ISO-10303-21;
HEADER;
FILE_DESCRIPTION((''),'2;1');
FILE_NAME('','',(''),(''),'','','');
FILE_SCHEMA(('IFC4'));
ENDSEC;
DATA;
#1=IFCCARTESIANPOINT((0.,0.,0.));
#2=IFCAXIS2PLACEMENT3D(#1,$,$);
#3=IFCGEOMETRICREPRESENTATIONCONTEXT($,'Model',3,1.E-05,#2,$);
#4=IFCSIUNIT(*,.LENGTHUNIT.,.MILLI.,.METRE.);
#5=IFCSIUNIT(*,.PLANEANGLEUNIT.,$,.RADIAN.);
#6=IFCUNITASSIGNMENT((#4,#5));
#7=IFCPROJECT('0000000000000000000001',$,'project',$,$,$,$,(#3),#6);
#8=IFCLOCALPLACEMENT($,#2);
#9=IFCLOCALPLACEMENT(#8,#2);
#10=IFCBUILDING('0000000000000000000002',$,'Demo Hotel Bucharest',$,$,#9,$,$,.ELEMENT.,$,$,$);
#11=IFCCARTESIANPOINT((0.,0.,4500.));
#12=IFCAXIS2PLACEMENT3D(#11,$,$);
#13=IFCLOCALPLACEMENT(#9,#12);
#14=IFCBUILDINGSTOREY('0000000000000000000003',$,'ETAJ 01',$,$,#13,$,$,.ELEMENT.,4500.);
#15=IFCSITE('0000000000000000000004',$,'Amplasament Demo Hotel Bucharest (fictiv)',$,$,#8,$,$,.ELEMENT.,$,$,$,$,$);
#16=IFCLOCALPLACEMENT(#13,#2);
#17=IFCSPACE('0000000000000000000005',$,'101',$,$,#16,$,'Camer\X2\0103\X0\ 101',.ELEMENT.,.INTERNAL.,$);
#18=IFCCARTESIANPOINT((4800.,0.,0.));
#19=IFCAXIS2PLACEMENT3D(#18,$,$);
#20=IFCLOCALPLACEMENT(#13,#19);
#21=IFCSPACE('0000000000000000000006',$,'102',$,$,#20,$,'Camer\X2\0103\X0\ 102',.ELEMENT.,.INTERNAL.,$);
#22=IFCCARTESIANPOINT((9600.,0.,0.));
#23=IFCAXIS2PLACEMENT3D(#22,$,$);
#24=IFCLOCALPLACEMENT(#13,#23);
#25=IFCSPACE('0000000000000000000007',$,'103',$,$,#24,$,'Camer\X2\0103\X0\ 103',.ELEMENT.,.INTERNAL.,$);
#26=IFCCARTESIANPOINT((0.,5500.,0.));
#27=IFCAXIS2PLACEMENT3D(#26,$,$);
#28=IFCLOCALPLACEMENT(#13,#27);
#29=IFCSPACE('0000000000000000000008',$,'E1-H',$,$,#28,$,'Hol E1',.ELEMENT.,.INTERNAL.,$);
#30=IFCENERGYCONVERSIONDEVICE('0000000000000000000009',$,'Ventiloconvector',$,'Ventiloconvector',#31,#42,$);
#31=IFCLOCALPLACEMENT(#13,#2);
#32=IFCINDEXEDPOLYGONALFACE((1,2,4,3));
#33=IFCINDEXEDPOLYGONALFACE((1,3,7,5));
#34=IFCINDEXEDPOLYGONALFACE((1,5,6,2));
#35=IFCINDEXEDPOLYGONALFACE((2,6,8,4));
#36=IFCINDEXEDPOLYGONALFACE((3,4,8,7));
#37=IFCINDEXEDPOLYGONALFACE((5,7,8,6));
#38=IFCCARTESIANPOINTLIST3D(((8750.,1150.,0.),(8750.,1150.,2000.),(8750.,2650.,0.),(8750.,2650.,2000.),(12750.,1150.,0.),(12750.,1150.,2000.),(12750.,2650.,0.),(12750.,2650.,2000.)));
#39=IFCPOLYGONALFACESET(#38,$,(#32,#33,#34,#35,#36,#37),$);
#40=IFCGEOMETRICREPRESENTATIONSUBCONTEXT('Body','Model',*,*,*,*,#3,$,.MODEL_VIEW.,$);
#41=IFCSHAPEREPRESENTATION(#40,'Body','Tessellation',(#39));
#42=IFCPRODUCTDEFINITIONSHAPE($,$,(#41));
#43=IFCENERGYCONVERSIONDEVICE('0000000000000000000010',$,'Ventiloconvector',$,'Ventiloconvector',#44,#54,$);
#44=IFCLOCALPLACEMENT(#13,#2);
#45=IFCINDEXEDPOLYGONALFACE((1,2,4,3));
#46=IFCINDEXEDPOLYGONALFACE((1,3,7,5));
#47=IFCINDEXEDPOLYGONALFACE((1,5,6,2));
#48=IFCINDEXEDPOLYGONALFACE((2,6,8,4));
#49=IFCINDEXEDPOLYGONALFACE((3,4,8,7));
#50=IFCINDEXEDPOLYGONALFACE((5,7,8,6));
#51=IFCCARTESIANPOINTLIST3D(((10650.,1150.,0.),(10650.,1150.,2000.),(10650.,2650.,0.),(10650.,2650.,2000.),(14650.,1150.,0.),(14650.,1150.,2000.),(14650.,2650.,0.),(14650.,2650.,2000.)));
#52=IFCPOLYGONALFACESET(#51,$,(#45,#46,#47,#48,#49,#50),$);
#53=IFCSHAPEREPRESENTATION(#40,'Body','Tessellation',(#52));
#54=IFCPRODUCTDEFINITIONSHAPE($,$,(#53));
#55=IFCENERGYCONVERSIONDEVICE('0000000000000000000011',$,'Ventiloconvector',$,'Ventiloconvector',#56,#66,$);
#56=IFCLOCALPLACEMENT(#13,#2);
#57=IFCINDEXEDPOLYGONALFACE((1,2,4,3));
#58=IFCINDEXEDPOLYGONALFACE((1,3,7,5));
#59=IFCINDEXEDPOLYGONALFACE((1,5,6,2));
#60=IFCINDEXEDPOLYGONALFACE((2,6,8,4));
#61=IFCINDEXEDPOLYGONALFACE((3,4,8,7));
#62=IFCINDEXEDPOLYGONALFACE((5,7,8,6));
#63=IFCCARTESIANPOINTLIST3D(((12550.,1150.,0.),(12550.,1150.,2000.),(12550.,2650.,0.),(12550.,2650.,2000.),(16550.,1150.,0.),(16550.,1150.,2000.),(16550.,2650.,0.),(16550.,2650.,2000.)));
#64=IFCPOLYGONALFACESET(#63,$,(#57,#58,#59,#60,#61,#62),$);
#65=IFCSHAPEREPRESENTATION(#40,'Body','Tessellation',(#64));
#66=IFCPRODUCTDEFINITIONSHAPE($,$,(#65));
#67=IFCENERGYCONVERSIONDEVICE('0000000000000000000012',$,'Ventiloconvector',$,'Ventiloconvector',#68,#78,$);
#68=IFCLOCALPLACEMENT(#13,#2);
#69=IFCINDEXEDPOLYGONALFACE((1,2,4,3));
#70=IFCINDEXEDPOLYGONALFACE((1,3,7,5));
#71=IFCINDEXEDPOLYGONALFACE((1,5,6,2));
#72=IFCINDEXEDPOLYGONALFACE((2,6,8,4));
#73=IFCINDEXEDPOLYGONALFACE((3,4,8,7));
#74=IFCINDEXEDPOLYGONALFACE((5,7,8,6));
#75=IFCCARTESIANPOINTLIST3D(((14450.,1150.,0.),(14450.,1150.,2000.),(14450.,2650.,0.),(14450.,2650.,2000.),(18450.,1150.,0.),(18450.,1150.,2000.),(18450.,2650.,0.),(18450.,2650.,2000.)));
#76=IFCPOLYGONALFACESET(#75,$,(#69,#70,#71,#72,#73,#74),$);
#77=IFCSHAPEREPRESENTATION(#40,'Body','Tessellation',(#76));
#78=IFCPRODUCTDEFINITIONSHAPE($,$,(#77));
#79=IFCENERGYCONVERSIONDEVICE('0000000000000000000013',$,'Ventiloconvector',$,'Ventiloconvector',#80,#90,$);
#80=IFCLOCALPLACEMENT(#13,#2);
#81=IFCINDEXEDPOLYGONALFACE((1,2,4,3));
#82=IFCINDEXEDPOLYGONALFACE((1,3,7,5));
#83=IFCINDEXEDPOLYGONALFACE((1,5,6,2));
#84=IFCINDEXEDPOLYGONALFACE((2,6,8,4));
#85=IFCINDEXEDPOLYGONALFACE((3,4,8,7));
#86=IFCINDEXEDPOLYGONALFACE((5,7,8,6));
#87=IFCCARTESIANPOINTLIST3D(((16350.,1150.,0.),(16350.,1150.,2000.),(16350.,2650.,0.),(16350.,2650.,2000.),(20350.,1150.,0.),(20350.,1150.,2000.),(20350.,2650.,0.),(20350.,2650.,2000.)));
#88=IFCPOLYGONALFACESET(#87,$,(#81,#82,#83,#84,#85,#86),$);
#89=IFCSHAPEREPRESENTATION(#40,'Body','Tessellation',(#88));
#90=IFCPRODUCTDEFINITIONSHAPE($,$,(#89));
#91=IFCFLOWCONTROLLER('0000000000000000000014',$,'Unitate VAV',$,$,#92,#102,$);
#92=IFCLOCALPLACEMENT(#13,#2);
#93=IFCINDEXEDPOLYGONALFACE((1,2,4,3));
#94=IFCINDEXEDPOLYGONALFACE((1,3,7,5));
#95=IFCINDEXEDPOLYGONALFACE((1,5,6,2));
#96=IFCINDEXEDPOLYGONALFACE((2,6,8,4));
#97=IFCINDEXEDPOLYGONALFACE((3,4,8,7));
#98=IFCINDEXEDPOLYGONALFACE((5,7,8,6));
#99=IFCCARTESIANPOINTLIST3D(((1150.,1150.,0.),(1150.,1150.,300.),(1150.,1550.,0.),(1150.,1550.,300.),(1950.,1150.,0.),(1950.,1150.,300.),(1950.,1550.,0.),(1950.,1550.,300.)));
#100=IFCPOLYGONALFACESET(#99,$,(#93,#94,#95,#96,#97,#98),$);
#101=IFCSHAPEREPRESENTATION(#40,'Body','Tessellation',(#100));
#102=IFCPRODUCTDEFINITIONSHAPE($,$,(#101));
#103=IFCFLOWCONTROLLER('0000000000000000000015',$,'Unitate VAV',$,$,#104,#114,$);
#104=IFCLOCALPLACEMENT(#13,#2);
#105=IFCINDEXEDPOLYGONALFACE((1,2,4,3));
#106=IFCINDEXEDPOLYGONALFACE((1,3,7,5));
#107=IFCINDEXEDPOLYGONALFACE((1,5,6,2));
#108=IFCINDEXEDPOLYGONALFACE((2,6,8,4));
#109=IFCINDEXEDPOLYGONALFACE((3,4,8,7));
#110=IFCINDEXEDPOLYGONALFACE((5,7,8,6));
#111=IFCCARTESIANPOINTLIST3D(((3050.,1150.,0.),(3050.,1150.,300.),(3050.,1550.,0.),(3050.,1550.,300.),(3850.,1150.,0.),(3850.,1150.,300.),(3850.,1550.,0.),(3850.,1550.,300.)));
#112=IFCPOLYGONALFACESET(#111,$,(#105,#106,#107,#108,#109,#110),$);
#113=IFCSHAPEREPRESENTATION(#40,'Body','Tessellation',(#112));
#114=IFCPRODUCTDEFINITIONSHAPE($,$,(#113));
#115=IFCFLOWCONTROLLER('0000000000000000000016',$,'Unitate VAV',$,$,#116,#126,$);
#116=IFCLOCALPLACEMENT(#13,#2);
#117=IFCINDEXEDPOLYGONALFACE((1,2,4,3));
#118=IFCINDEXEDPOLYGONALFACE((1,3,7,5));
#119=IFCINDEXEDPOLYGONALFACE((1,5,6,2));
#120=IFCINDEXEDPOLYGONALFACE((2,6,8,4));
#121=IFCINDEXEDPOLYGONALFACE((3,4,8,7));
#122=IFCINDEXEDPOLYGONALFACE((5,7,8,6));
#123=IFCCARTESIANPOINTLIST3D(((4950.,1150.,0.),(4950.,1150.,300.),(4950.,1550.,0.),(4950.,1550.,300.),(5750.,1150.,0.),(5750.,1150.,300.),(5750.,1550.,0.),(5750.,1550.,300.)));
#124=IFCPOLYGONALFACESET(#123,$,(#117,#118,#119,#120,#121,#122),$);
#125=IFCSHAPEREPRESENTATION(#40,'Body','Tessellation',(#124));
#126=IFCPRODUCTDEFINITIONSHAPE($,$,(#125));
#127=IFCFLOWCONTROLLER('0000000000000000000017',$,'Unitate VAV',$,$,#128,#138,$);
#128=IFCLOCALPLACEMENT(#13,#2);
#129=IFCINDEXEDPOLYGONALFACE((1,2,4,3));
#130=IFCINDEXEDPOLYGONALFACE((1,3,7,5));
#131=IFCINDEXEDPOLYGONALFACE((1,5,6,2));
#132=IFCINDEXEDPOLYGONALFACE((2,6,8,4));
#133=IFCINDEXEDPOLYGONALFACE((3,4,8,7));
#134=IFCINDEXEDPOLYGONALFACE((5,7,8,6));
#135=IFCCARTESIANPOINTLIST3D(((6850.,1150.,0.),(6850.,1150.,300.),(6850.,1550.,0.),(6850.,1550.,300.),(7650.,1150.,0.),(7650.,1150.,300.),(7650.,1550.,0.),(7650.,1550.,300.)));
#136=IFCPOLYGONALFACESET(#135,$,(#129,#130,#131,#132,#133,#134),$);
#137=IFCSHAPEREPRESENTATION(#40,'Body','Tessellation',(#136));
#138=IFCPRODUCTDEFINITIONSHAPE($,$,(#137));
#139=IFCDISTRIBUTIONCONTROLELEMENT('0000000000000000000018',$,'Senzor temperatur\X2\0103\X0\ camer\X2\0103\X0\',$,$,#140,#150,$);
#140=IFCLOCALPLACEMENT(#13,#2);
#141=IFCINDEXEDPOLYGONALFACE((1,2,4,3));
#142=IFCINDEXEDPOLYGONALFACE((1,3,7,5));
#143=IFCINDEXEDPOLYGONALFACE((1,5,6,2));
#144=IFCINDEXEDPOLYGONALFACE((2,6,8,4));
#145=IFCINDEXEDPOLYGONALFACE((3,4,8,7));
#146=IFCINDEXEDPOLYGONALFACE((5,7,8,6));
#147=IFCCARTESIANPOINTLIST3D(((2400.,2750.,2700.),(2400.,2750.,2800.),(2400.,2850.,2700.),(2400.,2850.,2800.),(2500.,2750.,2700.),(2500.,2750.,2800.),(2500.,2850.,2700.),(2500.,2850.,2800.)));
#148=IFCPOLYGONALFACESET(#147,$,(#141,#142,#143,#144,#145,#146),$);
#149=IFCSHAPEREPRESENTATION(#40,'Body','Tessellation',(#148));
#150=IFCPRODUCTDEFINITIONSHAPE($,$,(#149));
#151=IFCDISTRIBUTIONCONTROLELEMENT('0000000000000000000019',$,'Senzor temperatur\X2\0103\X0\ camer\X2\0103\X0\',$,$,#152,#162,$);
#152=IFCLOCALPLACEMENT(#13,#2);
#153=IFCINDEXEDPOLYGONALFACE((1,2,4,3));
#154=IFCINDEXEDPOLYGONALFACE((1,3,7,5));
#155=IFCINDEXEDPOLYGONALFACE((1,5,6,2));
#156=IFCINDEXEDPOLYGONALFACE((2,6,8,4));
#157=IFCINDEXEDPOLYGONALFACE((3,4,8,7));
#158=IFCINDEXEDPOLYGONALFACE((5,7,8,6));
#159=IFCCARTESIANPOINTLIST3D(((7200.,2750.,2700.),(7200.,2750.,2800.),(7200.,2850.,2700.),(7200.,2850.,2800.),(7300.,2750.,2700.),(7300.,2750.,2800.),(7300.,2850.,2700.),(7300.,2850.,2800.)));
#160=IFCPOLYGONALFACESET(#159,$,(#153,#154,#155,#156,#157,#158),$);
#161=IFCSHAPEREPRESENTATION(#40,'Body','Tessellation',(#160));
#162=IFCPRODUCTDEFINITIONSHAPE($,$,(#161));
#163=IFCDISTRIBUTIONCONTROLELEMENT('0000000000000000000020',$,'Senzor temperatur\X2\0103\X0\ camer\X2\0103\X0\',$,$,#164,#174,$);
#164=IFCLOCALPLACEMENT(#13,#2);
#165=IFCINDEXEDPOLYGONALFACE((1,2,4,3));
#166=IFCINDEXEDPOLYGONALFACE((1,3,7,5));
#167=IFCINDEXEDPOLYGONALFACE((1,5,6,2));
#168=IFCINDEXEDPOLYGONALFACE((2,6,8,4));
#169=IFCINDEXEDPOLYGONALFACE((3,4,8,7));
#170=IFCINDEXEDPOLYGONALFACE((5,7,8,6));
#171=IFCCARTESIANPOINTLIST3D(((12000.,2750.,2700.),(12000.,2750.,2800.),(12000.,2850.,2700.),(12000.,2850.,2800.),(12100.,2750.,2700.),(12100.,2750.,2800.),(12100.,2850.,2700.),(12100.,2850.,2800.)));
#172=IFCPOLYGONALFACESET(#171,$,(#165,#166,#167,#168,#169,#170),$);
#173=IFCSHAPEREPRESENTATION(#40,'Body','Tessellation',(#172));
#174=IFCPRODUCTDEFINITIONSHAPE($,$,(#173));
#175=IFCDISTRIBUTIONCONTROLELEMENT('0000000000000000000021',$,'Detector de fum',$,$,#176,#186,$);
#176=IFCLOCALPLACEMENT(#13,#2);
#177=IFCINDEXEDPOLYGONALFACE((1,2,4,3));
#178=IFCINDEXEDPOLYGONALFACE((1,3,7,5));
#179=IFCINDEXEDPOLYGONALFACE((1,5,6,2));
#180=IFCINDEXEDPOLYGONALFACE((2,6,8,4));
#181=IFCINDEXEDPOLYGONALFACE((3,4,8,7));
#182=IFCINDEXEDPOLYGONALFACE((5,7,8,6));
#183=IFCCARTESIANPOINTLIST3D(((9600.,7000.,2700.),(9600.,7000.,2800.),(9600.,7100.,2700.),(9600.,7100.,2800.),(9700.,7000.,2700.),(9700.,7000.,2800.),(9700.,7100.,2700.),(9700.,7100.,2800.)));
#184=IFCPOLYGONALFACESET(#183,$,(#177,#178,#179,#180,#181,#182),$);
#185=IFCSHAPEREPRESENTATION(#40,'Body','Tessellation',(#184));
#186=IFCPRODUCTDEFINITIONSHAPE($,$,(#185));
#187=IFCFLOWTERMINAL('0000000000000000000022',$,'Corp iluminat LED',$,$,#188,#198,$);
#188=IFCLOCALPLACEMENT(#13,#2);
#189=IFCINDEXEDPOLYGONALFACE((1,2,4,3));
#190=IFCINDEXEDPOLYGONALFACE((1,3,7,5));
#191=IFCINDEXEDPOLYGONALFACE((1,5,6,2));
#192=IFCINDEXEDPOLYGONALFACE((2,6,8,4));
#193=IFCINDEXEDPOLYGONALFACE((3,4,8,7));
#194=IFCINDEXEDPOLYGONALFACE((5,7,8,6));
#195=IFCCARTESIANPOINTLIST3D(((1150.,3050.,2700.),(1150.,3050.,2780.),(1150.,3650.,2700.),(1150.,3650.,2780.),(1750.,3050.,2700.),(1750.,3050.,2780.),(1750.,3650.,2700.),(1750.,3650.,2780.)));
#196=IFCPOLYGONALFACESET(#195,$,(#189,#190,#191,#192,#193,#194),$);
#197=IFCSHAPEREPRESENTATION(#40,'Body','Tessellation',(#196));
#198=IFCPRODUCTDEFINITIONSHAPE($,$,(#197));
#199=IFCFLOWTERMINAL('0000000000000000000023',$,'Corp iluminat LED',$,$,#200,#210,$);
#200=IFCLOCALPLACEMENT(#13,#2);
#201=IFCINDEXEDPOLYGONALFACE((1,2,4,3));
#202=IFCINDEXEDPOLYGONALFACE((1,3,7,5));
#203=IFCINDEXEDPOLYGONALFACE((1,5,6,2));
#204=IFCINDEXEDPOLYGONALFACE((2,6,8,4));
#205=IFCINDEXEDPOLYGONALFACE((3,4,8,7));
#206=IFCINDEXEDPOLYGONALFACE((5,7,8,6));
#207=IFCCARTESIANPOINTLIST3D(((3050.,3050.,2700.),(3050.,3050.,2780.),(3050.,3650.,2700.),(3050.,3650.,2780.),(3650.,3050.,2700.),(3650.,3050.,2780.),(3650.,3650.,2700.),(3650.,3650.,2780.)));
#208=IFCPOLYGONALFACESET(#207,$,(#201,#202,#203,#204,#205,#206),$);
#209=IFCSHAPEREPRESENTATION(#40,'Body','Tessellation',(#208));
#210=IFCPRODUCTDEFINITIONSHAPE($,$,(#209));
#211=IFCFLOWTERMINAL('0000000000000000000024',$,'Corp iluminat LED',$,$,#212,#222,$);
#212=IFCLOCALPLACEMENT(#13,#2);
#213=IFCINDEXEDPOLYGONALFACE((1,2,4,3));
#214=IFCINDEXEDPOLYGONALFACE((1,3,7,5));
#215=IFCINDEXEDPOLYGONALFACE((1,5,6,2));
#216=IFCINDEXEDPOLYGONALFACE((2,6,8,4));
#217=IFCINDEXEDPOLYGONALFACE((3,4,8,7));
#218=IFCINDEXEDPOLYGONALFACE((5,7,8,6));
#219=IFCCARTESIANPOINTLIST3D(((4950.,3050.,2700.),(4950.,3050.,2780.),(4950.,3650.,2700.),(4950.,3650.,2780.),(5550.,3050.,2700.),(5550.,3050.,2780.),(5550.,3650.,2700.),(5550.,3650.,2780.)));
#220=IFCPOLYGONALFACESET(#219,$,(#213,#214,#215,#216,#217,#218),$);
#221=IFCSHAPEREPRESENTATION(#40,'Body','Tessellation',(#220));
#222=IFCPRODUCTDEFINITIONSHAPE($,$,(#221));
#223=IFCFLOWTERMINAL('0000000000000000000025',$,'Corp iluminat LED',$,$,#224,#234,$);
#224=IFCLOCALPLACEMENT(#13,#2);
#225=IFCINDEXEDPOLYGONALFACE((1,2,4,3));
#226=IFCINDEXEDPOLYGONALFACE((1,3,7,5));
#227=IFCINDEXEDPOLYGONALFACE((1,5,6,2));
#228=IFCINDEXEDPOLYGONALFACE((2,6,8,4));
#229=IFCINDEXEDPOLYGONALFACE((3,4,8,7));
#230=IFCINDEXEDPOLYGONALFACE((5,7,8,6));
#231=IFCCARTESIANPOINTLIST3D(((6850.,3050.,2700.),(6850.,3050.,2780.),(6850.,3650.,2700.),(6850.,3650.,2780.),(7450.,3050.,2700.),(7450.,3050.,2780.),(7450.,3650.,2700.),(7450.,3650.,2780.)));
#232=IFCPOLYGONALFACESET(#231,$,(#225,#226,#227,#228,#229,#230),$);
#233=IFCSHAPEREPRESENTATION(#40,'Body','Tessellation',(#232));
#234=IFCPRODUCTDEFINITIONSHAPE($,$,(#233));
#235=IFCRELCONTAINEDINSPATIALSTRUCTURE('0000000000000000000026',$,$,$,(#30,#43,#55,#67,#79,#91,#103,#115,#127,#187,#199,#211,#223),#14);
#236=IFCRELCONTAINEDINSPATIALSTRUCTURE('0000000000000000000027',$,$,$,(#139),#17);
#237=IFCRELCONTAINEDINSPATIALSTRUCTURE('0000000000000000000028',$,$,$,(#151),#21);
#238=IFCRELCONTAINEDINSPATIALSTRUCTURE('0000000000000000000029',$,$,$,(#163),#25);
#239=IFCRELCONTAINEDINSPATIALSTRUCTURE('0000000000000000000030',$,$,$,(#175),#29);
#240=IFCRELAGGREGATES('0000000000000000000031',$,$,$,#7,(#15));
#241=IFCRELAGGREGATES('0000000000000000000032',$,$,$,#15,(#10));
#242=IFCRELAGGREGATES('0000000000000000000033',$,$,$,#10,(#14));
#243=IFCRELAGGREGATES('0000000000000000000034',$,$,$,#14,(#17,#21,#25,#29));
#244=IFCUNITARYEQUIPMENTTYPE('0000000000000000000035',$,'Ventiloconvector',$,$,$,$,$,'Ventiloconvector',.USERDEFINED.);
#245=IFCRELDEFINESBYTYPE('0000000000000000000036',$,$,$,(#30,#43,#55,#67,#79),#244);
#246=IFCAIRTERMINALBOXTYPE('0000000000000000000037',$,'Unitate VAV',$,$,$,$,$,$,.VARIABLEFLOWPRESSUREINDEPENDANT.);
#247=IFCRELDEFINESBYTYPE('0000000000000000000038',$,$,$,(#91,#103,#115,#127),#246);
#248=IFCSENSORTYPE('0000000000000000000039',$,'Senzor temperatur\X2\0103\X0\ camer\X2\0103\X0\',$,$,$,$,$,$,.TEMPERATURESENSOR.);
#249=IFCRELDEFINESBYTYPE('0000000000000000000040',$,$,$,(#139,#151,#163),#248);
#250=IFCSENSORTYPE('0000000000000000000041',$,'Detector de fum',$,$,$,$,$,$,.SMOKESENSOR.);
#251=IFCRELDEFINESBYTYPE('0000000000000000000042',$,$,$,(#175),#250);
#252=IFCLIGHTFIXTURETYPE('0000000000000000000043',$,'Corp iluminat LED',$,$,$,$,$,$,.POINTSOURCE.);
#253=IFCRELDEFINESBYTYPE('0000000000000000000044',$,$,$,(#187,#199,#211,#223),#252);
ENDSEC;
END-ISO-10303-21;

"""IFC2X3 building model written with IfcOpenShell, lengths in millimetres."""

from ifc_helpers import new_model, si_unit, frame, frame_2d, origin, place, context, subcontext, project, spatial, rectangle, extrude, type_object, element, save


model = new_model("IFC2X3")

# Units and contexts
model_context = context("Model", 3, precision=1e-05, world=origin())
body_context = subcontext(model_context, "Body", "Model", "MODEL_VIEW")
ifc_project = project(units=[si_unit("LENGTHUNIT", "METRE", prefix="MILLI"), si_unit("PLANEANGLEUNIT", "RADIAN")], contexts=[model_context])

# Site, building, storey
site_placement = place(None, origin())
site = spatial("IfcSite", under=ifc_project, at=site_placement, Name="Amplasament Demo Hotel Bucharest (fictiv)", CompositionType="ELEMENT")
building_placement = place(site_placement, origin())
building = spatial("IfcBuilding", under=site, at=building_placement, Name="Demo Hotel Bucharest", CompositionType="ELEMENT")
storey_placement = place(building_placement, frame((0.0, 0.0, 4500.0)))
storey = spatial("IfcBuildingStorey", under=building, at=storey_placement, Name="ETAJ 01", CompositionType="ELEMENT", Elevation=4500.0)

# Energy conversion devices
unitary_equipment_type = type_object("IfcUnitaryEquipmentType", Name="Ventiloconvector", ElementType="Ventiloconvector", PredefinedType="USERDEFINED")
for number, where, name in (
    (1, (8750.0, 1150.0, 0.0), "Ventiloconvector"),
    (2, (10650.0, 1150.0, 0.0), "Ventiloconvector"),
    (3, (12550.0, 1150.0, 0.0), "Ventiloconvector"),
    (4, (14450.0, 1150.0, 0.0), "Ventiloconvector"),
    (5, (16350.0, 1150.0, 0.0), "Ventiloconvector"),
):
    element("IfcEnergyConversionDevice", number, at=place(storey_placement, frame(where)), inside=storey, type_object=unitary_equipment_type, Name=name, ObjectType="Ventiloconvector", context=body_context, shape_type="SweptSolid", body=[
        extrude(rectangle(XDim=4000.0, YDim=1500.0, at=frame_2d((2000.0, 750.0))), origin(), (0.0, 0.0, 1.0), 2000.0),
    ])

# Flow controllers
air_terminal_box_type = type_object("IfcAirTerminalBoxType", Name="Unitate VAV", PredefinedType="VARIABLEFLOWPRESSUREINDEPENDANT")
for number, where, name in (
    (6, (1150.0, 1150.0, 0.0), "Unitate VAV"),
    (7, (3050.0, 1150.0, 0.0), "Unitate VAV"),
    (8, (4950.0, 1150.0, 0.0), "Unitate VAV"),
    (9, (6850.0, 1150.0, 0.0), "Unitate VAV"),
):
    element("IfcFlowController", number, at=place(storey_placement, frame(where)), inside=storey, type_object=air_terminal_box_type, Name=name, context=body_context, shape_type="SweptSolid", body=[
        extrude(rectangle(XDim=800.0, YDim=400.0, at=frame_2d((400.0, 200.0))), origin(), (0.0, 0.0, 1.0), 300.0),
    ])

# Shared definitions
space_1_placement = place(storey_placement, origin())
space_1 = spatial("IfcSpace", under=storey, at=space_1_placement, Name="101", LongName="Cameră 101", CompositionType="ELEMENT", InteriorOrExteriorSpace="INTERNAL")

# Distribution control element
sensor_type_1 = type_object("IfcSensorType", Name="Senzor temperatură cameră", PredefinedType="TEMPERATURESENSOR")
distribution_control_element_1_placement = place(storey_placement, frame((2400.0, 2750.0, 2700.0)))
element("IfcDistributionControlElement", 10, at=distribution_control_element_1_placement, inside=space_1, type_object=sensor_type_1, Name="Senzor temperatură cameră", context=body_context, shape_type="SweptSolid", body=[
    extrude(rectangle(XDim=100.0, YDim=100.0, at=frame_2d((50.0, 50.0))), origin(), (0.0, 0.0, 1.0), 100.0),
])

# Shared definitions
space_2_placement = place(storey_placement, frame((4800.0, 0.0, 0.0)))
space_2 = spatial("IfcSpace", under=storey, at=space_2_placement, Name="102", LongName="Cameră 102", CompositionType="ELEMENT", InteriorOrExteriorSpace="INTERNAL")

# Distribution control element
distribution_control_element_2_placement = place(storey_placement, frame((7200.0, 2750.0, 2700.0)))
element("IfcDistributionControlElement", 11, at=distribution_control_element_2_placement, inside=space_2, type_object=sensor_type_1, Name="Senzor temperatură cameră", context=body_context, shape_type="SweptSolid", body=[
    extrude(rectangle(XDim=100.0, YDim=100.0, at=frame_2d((50.0, 50.0))), origin(), (0.0, 0.0, 1.0), 100.0),
])

# Shared definitions
space_3_placement = place(storey_placement, frame((9600.0, 0.0, 0.0)))
space_3 = spatial("IfcSpace", under=storey, at=space_3_placement, Name="103", LongName="Cameră 103", CompositionType="ELEMENT", InteriorOrExteriorSpace="INTERNAL")

# Distribution control element
distribution_control_element_3_placement = place(storey_placement, frame((12000.0, 2750.0, 2700.0)))
element("IfcDistributionControlElement", 12, at=distribution_control_element_3_placement, inside=space_3, type_object=sensor_type_1, Name="Senzor temperatură cameră", context=body_context, shape_type="SweptSolid", body=[
    extrude(rectangle(XDim=100.0, YDim=100.0, at=frame_2d((50.0, 50.0))), origin(), (0.0, 0.0, 1.0), 100.0),
])

# Shared definitions
space_4_placement = place(storey_placement, frame((0.0, 5500.0, 0.0)))
space_4 = spatial("IfcSpace", under=storey, at=space_4_placement, Name="E1-H", LongName="Hol E1", CompositionType="ELEMENT", InteriorOrExteriorSpace="INTERNAL")

# Distribution control element
sensor_type_2 = type_object("IfcSensorType", Name="Detector de fum", PredefinedType="SMOKESENSOR")
distribution_control_element_4_placement = place(storey_placement, frame((9600.0, 7000.0, 2700.0)))
element("IfcDistributionControlElement", 13, at=distribution_control_element_4_placement, inside=space_4, type_object=sensor_type_2, Name="Detector de fum", context=body_context, shape_type="SweptSolid", body=[
    extrude(rectangle(XDim=100.0, YDim=100.0, at=frame_2d((50.0, 50.0))), origin(), (0.0, 0.0, 1.0), 100.0),
])

# Flow terminals
light_fixture_type = type_object("IfcLightFixtureType", Name="Corp iluminat LED", PredefinedType="POINTSOURCE")
for number, where, name in (
    (14, (1150.0, 3050.0, 2700.0), "Corp iluminat LED"),
    (15, (3050.0, 3050.0, 2700.0), "Corp iluminat LED"),
    (16, (4950.0, 3050.0, 2700.0), "Corp iluminat LED"),
    (17, (6850.0, 3050.0, 2700.0), "Corp iluminat LED"),
):
    element("IfcFlowTerminal", number, at=place(storey_placement, frame(where)), inside=storey, type_object=light_fixture_type, Name=name, context=body_context, shape_type="SweptSolid", body=[
        extrude(rectangle(XDim=600.0, YDim=600.0, at=frame_2d((300.0, 300.0))), origin(), (0.0, 0.0, 1.0), 80.0),
    ])

save(model, "model.ifc")
